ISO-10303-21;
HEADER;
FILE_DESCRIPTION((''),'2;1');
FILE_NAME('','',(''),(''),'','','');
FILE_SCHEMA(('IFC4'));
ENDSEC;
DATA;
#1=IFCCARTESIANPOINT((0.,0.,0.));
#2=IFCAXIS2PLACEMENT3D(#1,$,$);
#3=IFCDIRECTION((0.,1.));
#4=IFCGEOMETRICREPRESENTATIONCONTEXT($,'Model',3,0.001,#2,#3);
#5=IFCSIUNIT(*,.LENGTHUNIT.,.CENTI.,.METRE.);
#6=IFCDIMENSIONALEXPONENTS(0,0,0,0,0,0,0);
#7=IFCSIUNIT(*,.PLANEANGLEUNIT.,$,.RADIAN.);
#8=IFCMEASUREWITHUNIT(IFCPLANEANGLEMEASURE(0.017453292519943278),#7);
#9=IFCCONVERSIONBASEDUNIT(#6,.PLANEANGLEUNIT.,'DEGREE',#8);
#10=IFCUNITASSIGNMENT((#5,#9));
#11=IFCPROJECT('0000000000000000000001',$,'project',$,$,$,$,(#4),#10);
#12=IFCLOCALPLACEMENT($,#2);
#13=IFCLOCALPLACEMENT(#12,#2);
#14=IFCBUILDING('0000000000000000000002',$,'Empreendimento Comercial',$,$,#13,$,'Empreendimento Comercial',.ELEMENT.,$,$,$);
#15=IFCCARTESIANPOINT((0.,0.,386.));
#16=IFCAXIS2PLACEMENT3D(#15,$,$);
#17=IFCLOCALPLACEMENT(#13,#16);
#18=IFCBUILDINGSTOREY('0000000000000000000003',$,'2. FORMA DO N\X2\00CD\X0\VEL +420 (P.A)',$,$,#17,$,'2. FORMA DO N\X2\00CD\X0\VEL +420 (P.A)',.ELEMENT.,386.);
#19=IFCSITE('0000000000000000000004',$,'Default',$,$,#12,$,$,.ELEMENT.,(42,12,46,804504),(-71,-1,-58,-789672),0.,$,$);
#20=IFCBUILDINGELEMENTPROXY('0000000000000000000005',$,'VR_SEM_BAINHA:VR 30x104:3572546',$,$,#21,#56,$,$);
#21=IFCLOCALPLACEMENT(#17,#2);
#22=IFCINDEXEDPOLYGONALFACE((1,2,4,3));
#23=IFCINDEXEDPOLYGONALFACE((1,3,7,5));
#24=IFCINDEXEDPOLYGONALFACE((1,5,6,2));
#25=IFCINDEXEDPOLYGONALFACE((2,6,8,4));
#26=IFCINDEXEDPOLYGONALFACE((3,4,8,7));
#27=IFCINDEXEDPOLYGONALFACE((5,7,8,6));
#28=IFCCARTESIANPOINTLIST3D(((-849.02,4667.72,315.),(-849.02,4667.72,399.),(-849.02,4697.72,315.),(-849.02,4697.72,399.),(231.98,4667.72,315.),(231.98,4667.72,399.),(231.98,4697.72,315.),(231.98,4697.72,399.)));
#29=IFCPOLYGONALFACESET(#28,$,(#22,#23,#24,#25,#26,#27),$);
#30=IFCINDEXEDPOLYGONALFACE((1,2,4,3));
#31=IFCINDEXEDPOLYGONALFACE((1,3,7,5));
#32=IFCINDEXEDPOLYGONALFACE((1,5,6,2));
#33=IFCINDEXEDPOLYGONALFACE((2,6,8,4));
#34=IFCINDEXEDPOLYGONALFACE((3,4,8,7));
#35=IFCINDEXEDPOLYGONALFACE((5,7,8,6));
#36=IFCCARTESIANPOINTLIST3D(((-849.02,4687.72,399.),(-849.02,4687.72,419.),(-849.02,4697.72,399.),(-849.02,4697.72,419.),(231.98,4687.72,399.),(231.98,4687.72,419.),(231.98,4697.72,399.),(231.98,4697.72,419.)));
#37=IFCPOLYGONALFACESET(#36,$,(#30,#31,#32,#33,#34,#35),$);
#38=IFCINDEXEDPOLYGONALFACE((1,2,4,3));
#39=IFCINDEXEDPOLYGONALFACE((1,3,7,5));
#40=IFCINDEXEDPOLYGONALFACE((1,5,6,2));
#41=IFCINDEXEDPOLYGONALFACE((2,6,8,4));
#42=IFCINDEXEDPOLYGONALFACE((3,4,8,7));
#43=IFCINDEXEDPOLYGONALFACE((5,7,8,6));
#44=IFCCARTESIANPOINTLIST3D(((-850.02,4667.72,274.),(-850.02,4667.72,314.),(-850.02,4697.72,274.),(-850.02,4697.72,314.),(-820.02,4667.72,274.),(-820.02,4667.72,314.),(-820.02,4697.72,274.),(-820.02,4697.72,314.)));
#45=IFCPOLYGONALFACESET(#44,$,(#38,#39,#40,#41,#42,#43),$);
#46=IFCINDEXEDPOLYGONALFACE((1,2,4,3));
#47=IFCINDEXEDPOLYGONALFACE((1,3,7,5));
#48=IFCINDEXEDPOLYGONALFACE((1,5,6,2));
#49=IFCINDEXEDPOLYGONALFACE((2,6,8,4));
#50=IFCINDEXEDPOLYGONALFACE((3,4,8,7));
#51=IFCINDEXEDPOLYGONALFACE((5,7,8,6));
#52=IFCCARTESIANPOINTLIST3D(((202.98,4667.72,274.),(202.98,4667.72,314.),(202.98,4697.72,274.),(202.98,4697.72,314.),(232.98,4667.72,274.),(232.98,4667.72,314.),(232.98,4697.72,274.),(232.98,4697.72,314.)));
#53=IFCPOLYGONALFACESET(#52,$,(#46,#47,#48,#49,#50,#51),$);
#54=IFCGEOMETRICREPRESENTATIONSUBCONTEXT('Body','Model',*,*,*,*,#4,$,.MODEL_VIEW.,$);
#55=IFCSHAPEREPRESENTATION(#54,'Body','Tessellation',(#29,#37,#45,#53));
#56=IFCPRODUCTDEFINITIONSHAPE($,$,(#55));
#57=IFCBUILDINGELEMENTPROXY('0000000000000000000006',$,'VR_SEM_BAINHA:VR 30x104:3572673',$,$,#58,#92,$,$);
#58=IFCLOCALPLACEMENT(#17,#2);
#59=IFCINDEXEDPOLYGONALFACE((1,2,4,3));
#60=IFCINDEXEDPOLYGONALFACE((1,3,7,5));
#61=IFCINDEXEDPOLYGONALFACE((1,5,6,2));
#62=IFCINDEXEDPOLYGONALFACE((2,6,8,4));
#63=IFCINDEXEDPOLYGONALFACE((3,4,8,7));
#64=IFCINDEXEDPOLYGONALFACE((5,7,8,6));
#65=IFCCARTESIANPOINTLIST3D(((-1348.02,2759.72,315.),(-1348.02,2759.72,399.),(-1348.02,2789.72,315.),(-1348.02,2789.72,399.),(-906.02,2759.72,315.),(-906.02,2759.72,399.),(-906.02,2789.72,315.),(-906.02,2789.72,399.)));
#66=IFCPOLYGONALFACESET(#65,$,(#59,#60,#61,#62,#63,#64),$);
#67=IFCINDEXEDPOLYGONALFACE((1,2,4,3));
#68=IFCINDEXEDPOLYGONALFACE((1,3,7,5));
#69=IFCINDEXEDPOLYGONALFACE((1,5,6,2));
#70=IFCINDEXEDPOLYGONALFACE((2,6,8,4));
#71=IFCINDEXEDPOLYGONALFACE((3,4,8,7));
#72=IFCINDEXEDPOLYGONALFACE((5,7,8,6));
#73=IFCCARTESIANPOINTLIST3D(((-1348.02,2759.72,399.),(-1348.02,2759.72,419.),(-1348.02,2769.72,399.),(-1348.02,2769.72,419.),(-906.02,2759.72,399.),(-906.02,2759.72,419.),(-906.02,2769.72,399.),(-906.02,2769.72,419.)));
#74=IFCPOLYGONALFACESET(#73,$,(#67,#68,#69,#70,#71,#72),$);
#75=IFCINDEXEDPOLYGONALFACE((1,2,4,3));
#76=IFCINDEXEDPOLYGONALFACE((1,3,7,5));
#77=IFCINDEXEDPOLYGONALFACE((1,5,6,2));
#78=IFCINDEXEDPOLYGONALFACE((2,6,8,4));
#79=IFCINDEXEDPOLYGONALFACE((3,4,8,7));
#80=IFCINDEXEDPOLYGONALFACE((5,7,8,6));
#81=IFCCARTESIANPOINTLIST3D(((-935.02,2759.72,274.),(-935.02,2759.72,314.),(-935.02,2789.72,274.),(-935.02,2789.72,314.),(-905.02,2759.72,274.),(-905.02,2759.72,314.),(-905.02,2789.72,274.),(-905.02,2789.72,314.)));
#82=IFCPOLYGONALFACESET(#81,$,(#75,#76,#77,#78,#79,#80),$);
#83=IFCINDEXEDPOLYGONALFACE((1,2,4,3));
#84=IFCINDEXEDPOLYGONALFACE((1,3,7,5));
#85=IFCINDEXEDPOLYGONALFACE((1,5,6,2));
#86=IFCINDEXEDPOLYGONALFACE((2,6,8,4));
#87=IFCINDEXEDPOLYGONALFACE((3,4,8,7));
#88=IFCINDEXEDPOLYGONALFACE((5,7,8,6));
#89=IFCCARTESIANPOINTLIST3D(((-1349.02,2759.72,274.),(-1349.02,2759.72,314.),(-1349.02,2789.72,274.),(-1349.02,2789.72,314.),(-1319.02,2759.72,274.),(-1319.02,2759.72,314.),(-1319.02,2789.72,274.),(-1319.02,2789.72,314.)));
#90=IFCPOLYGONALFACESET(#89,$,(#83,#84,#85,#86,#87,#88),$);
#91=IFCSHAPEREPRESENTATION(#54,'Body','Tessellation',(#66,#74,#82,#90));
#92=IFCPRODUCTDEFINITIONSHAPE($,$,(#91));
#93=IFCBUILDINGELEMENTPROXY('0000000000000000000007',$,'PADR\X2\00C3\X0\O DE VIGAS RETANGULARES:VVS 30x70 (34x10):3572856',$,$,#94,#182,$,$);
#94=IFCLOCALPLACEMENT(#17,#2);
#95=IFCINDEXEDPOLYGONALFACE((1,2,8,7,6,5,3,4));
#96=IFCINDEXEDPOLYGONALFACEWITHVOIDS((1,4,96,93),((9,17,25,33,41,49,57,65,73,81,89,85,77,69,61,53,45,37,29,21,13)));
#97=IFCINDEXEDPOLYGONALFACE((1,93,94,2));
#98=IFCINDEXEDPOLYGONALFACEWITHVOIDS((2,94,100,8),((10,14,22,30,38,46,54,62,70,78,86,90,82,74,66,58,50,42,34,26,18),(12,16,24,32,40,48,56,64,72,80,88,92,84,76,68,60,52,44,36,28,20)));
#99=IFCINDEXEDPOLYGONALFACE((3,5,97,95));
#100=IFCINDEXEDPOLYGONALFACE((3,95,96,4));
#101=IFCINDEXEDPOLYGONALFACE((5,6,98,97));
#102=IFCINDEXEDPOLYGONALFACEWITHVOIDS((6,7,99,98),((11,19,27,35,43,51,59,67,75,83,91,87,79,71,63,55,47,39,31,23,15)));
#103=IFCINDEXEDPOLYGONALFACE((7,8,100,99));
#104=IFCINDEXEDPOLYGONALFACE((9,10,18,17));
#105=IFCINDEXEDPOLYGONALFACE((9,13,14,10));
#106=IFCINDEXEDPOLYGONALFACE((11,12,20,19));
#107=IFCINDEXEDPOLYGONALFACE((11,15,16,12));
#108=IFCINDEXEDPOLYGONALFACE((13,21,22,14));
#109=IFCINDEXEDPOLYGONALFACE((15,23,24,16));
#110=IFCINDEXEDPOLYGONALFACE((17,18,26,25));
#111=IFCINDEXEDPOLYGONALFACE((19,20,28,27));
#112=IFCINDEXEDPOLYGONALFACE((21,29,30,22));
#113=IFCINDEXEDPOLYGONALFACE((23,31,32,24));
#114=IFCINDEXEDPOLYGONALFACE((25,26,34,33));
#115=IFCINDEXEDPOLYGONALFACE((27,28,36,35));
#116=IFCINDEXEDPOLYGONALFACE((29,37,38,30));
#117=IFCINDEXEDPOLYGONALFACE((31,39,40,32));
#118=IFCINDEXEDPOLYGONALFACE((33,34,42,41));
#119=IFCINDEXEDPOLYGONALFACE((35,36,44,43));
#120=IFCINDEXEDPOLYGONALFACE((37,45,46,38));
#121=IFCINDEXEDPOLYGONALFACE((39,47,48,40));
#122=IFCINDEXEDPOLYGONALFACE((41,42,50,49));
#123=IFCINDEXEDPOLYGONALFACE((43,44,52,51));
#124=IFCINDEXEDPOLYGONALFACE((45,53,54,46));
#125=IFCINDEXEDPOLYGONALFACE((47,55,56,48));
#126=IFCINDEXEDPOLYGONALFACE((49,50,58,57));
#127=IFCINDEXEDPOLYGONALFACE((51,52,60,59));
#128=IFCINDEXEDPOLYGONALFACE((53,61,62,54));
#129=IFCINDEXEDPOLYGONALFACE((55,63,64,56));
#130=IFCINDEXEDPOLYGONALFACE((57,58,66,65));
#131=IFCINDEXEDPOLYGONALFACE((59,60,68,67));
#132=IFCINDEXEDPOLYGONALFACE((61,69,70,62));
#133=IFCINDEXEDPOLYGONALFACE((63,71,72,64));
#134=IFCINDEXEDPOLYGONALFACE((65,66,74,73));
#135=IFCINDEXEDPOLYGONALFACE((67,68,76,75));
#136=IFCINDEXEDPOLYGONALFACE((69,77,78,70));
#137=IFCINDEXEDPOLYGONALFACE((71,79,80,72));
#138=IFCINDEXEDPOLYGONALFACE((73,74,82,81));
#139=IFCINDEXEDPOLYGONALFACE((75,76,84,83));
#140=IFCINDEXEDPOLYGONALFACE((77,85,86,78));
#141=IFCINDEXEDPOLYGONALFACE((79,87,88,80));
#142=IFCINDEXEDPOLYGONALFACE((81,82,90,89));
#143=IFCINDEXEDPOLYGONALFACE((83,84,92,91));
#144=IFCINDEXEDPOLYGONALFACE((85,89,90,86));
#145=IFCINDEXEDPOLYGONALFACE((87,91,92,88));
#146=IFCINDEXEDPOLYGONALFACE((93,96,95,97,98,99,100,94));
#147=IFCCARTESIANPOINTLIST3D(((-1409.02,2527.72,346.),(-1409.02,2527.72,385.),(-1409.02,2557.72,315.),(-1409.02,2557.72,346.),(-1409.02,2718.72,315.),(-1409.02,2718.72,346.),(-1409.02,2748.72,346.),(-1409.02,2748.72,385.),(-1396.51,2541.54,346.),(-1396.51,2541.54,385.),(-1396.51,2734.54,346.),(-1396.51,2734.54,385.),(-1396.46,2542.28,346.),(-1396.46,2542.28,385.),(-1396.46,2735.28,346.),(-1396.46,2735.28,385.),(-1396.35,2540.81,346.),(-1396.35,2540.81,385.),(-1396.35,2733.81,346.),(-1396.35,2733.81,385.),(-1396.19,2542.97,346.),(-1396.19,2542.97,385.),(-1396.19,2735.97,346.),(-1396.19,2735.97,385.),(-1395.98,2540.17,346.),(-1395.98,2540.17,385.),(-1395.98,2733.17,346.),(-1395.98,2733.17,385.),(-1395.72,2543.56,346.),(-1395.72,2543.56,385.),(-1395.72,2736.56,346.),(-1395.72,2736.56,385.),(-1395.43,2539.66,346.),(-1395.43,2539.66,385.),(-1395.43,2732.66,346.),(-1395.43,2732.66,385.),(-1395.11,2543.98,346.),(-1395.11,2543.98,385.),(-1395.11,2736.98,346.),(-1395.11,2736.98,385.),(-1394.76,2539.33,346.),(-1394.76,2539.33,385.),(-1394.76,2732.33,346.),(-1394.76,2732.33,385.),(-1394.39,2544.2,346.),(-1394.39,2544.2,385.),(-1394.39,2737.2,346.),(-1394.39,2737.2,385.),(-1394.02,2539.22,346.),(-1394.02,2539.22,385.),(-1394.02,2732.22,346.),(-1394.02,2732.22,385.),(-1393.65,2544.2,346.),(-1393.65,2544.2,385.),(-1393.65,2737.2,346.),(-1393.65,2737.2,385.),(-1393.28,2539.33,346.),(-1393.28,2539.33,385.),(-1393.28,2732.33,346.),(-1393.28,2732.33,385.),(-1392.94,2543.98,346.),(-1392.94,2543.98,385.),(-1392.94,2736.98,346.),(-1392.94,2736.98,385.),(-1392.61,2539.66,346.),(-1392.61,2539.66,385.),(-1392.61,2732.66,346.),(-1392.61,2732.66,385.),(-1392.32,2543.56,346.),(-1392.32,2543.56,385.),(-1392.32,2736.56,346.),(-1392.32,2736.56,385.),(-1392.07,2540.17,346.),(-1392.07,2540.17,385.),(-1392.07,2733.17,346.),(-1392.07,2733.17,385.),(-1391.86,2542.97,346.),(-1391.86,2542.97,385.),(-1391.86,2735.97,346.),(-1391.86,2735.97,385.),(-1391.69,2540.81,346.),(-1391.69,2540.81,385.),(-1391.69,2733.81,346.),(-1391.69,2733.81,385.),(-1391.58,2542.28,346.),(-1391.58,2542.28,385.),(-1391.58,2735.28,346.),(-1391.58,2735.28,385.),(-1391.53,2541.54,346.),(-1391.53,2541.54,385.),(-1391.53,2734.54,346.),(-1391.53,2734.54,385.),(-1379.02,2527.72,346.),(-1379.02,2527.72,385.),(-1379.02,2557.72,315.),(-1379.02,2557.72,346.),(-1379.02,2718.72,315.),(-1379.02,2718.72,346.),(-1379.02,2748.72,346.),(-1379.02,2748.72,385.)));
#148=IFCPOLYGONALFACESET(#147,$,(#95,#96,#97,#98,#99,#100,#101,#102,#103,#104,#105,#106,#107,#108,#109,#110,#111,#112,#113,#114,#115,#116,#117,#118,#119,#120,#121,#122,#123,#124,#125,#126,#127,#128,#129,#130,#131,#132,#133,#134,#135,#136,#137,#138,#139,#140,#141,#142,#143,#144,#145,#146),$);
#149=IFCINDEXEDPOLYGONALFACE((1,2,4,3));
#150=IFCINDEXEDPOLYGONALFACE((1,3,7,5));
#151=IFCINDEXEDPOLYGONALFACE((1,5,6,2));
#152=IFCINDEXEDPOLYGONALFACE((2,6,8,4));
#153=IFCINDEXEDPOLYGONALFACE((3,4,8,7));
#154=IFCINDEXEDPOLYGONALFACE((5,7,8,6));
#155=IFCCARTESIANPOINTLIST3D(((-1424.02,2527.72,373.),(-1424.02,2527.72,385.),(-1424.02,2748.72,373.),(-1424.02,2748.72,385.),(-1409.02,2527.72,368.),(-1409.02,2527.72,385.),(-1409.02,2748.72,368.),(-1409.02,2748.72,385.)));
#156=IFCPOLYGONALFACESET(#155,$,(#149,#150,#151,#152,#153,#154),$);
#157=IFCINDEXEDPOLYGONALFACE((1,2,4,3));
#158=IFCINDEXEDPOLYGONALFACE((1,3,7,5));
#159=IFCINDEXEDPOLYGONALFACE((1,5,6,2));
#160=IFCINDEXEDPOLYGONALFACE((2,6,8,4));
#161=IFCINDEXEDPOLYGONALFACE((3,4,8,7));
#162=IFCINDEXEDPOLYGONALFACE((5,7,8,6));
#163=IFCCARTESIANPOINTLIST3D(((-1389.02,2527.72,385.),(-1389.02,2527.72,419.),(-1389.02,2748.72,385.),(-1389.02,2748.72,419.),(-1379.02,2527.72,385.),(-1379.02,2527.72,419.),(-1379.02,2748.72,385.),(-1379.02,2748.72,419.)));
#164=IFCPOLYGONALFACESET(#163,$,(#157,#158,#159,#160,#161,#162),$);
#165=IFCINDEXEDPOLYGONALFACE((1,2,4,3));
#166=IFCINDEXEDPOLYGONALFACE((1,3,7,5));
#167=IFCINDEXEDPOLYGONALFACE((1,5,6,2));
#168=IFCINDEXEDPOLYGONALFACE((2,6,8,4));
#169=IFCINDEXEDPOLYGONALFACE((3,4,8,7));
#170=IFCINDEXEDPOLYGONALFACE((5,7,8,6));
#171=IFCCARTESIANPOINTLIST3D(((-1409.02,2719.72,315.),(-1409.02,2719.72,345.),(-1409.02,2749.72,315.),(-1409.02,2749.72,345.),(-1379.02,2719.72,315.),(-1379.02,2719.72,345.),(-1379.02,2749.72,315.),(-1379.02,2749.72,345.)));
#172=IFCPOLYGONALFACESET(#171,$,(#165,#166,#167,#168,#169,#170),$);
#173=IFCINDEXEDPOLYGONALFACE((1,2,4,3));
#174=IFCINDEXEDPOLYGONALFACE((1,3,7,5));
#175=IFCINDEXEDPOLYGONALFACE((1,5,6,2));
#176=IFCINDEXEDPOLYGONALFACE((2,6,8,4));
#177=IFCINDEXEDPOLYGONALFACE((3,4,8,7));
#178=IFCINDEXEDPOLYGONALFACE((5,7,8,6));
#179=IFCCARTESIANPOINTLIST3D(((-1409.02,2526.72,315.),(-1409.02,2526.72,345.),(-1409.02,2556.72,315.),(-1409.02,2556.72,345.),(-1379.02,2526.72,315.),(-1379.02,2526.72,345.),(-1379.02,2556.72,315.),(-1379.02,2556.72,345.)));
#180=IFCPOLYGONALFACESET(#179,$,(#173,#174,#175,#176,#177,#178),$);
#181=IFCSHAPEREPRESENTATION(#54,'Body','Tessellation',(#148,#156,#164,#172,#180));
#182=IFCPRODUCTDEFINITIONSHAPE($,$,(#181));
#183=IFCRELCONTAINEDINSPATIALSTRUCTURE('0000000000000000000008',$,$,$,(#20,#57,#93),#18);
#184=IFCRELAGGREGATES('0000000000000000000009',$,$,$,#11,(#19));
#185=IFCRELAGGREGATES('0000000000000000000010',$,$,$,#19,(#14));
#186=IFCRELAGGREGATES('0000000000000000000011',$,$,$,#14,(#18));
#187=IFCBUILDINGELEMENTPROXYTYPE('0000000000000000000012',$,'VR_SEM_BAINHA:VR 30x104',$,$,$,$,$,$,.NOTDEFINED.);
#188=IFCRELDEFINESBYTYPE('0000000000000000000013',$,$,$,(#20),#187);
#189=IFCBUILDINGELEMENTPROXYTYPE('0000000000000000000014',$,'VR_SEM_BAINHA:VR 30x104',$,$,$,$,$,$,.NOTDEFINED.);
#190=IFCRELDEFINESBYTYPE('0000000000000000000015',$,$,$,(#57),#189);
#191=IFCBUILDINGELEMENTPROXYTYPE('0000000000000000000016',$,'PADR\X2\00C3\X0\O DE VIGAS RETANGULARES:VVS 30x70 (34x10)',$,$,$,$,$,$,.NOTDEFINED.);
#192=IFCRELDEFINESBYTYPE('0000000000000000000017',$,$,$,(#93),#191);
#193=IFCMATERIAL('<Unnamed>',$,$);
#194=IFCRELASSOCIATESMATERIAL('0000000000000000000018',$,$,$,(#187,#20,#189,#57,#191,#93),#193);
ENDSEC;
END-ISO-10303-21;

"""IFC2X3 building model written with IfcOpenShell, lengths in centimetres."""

from ifc_helpers import new_model, entity, si_unit, converted_unit, direction, frame, frame_2d, origin, origin_2d_with_axis, place, context, subcontext, project, spatial, polyline, rectangle, circle, outline, extrude, source, transform, mapped, material, type_object, type_shapes, element, save


model = new_model("IFC2X3")

# Units and contexts
model_context = context("Model", 3, precision=0.001, world=origin(), true_north=direction((0.0, 1.0)))
body_context = subcontext(model_context, "Body", "Model", "MODEL_VIEW")
ifc_project = project(units=[si_unit("LENGTHUNIT", "METRE", prefix="CENTI"), converted_unit("PLANEANGLEUNIT", "DEGREE", entity("IfcPlaneAngleMeasure", 0.017453292519943278), si_unit("PLANEANGLEUNIT", "RADIAN"), dimensions=[0, 0, 0, 0, 0, 0, 0])], contexts=[model_context])

# Site, building, storey
site_placement = place(None, origin())
site = spatial("IfcSite", under=ifc_project, at=site_placement, Name="Default", CompositionType="ELEMENT", RefLatitude=(42, 12, 46, 804504), RefLongitude=(-71, -1, -58, -789672), RefElevation=0.0)
building_placement = place(site_placement, origin())
building = spatial("IfcBuilding", under=site, at=building_placement, Name="Empreendimento Comercial", LongName="Empreendimento Comercial", CompositionType="ELEMENT")
storey_placement = place(building_placement, frame((0.0, 0.0, 386.0)))
storey = spatial("IfcBuildingStorey", under=building, at=storey_placement, Name="2. FORMA DO NÍVEL +420 (P.A)", LongName="2. FORMA DO NÍVEL +420 (P.A)", CompositionType="ELEMENT", Elevation=386.0)

# Building element proxies
ifc_material_1 = material(Name="<Unnamed>")
building_element_proxy_type_1 = type_object("IfcBuildingElementProxyType", Name="VR_SEM_BAINHA:VR 30x104", PredefinedType="NOTDEFINED", material=ifc_material_1)
shared_shape_1 = source(origin(), body_context, "Body", "SweptSolid", [
    extrude(rectangle(XDim=1081.0, YDim=30.0, at=origin_2d_with_axis()), frame((-308.52, 4682.72, 701.0), z_axis=(0.0, 0.0, 1.0), x_axis=(-1.0, 0.0, 0.0)), (0.0, 0.0, 1.0), 84.0),
    extrude(rectangle(XDim=1081.0, YDim=10.0, at=origin_2d_with_axis()), frame((-308.52, 4692.72, 785.0), z_axis=(0.0, 0.0, 1.0), x_axis=(-1.0, 0.0, 0.0)), (0.0, 0.0, 1.0), 20.0),
    extrude(rectangle(XDim=30.0, YDim=30.0, at=origin_2d_with_axis()), frame((-835.02, 4682.72, 660.0), z_axis=(0.0, 0.0, 1.0), x_axis=(0.0, 1.0, 0.0)), (0.0, 0.0, 1.0), 40.0),
    extrude(rectangle(XDim=30.0, YDim=30.0, at=origin_2d_with_axis()), frame((217.98, 4682.72, 660.0), z_axis=(0.0, 0.0, 1.0), x_axis=(0.0, 1.0, 0.0)), (0.0, 0.0, 1.0), 40.0),
])
type_shapes(building_element_proxy_type_1, [shared_shape_1])
proxy_1_placement = place(storey_placement, frame((0.0, 0.0, -386.0)))
element("IfcBuildingElementProxy", 1, at=proxy_1_placement, inside=storey, type_object=building_element_proxy_type_1, material=ifc_material_1, Name="VR_SEM_BAINHA:VR 30x104:3572546", context=body_context, shape_type="MappedRepresentation", body=[
    mapped(shared_shape_1, transform((0.0, 0.0, 0.0), scale=1.0)),
])
building_element_proxy_type_2 = type_object("IfcBuildingElementProxyType", Name="VR_SEM_BAINHA:VR 30x104", PredefinedType="NOTDEFINED", material=ifc_material_1)
shared_shape_2 = source(origin(), body_context, "Body", "SweptSolid", [
    extrude(rectangle(XDim=442.0, YDim=30.0, at=frame_2d((0.0, 0.0), x_axis=(1.0, 0.0))), frame((-1127.02, 2774.72, 701.0)), (0.0, 0.0, 1.0), 84.0),
    extrude(rectangle(XDim=442.0, YDim=10.0, at=frame_2d((0.0, 0.0), x_axis=(1.0, 0.0))), frame((-1127.02, 2764.72, 785.0)), (0.0, 0.0, 1.0), 20.0),
    extrude(rectangle(XDim=30.0, YDim=30.0, at=origin_2d_with_axis()), frame((-920.02, 2774.72, 660.0), z_axis=(0.0, 0.0, 1.0), x_axis=(0.0, -1.0, 0.0)), (0.0, 0.0, 1.0), 40.0),
    extrude(rectangle(XDim=30.0, YDim=30.0, at=frame_2d((0.0, 0.0), x_axis=(1.0, 0.0))), frame((-1334.02, 2774.72, 660.0), z_axis=(0.0, 0.0, 1.0), x_axis=(0.0, -1.0, 0.0)), (0.0, 0.0, 1.0), 40.0),
])
type_shapes(building_element_proxy_type_2, [shared_shape_2])
proxy_2_placement = place(storey_placement, frame((0.0, 0.0, -386.0)))
element("IfcBuildingElementProxy", 2, at=proxy_2_placement, inside=storey, type_object=building_element_proxy_type_2, material=ifc_material_1, Name="VR_SEM_BAINHA:VR 30x104:3572673", context=body_context, shape_type="MappedRepresentation", body=[
    mapped(shared_shape_2, transform((0.0, 0.0, 0.0), scale=1.0)),
])

# Building element proxy, openings
building_element_proxy_type_3 = type_object("IfcBuildingElementProxyType", Name="PADRÃO DE VIGAS RETANGULARES:VVS 30x70 (34x10)", PredefinedType="NOTDEFINED", material=ifc_material_1)
shared_shape_3 = source(origin(), body_context, "Body", "SweptSolid", [
    extrude(outline(polyline([(-37.0, -110.5), (2.0, -110.5), (2.0, -80.5), (33.0, -80.5), (33.0, 80.5), (2.0, 80.5), (2.0, 110.5), (-37.0, 110.5), (-37.0, -110.5)])), frame((-1409.02, 2638.22, 734.0), z_axis=(1.0, 0.0, 0.0), x_axis=(0.0, 0.0, -1.0)), (0.0, 0.0, 1.0), 30.0),
    extrude(outline(polyline([(-7.5, -7.25), (7.5, -7.25), (7.5, 9.75), (-7.5, 4.75), (-7.5, -7.25)])), frame((-1416.52, 2527.72, 763.75), z_axis=(0.0, 1.0, 0.0), x_axis=(1.0, 0.0, 0.0)), (0.0, 0.0, 1.0), 221.0),
    extrude(rectangle(XDim=221.0, YDim=10.0, at=frame_2d((0.0, 0.0), x_axis=(1.0, 0.0))), frame((-1384.02, 2638.22, 771.0), z_axis=(0.0, 0.0, 1.0), x_axis=(0.0, 1.0, 0.0)), (0.0, 0.0, 1.0), 34.0),
    extrude(rectangle(XDim=30.0, YDim=30.0, at=frame_2d((0.0, 0.0), x_axis=(1.0, 0.0))), frame((-1394.02, 2734.72, 701.0)), (0.0, 0.0, 1.0), 30.0),
    extrude(rectangle(XDim=30.0, YDim=30.0, at=origin_2d_with_axis()), frame((-1394.02, 2541.72, 701.0)), (0.0, 0.0, 1.0), 30.0),
])
type_shapes(building_element_proxy_type_3, [shared_shape_3])
proxy_3_placement = place(storey_placement, frame((0.0, 0.0, -386.0)))
proxy_3 = element("IfcBuildingElementProxy", 3, at=proxy_3_placement, inside=storey, type_object=building_element_proxy_type_3, material=ifc_material_1, Name="PADRÃO DE VIGAS RETANGULARES:VVS 30x70 (34x10):3572856", context=body_context, shape_type="MappedRepresentation", body=[
    mapped(shared_shape_3, transform((0.0, 0.0, 0.0), scale=1.0)),
])
opening_1_placement = place(storey_placement, frame((0.0, 0.0, -386.0)))
element("IfcOpeningElement", 4, at=opening_1_placement, cuts=proxy_3, ObjectType="Opening", context=body_context, shape_type="SweptSolid", body=[
    extrude(circle(Radius=2.5, at=origin_2d_with_axis()), frame((-1394.02, 2541.72, 732.0), z_axis=(0.0, 0.0, 1.0), x_axis=(0.0, -1.0, 0.0)), (0.0, 0.0, 1.0), 39.0),
])
opening_2_placement = place(storey_placement, frame((0.0, 0.0, -386.0)))
element("IfcOpeningElement", 5, at=opening_2_placement, cuts=proxy_3, ObjectType="Opening", context=body_context, shape_type="SweptSolid", body=[
    extrude(circle(Radius=2.5, at=origin_2d_with_axis()), frame((-1394.02, 2734.72, 732.0), z_axis=(0.0, 0.0, 1.0), x_axis=(0.0, -1.0, 0.0)), (0.0, 0.0, 1.0), 39.0),
])

save(model, "model.ifc")
